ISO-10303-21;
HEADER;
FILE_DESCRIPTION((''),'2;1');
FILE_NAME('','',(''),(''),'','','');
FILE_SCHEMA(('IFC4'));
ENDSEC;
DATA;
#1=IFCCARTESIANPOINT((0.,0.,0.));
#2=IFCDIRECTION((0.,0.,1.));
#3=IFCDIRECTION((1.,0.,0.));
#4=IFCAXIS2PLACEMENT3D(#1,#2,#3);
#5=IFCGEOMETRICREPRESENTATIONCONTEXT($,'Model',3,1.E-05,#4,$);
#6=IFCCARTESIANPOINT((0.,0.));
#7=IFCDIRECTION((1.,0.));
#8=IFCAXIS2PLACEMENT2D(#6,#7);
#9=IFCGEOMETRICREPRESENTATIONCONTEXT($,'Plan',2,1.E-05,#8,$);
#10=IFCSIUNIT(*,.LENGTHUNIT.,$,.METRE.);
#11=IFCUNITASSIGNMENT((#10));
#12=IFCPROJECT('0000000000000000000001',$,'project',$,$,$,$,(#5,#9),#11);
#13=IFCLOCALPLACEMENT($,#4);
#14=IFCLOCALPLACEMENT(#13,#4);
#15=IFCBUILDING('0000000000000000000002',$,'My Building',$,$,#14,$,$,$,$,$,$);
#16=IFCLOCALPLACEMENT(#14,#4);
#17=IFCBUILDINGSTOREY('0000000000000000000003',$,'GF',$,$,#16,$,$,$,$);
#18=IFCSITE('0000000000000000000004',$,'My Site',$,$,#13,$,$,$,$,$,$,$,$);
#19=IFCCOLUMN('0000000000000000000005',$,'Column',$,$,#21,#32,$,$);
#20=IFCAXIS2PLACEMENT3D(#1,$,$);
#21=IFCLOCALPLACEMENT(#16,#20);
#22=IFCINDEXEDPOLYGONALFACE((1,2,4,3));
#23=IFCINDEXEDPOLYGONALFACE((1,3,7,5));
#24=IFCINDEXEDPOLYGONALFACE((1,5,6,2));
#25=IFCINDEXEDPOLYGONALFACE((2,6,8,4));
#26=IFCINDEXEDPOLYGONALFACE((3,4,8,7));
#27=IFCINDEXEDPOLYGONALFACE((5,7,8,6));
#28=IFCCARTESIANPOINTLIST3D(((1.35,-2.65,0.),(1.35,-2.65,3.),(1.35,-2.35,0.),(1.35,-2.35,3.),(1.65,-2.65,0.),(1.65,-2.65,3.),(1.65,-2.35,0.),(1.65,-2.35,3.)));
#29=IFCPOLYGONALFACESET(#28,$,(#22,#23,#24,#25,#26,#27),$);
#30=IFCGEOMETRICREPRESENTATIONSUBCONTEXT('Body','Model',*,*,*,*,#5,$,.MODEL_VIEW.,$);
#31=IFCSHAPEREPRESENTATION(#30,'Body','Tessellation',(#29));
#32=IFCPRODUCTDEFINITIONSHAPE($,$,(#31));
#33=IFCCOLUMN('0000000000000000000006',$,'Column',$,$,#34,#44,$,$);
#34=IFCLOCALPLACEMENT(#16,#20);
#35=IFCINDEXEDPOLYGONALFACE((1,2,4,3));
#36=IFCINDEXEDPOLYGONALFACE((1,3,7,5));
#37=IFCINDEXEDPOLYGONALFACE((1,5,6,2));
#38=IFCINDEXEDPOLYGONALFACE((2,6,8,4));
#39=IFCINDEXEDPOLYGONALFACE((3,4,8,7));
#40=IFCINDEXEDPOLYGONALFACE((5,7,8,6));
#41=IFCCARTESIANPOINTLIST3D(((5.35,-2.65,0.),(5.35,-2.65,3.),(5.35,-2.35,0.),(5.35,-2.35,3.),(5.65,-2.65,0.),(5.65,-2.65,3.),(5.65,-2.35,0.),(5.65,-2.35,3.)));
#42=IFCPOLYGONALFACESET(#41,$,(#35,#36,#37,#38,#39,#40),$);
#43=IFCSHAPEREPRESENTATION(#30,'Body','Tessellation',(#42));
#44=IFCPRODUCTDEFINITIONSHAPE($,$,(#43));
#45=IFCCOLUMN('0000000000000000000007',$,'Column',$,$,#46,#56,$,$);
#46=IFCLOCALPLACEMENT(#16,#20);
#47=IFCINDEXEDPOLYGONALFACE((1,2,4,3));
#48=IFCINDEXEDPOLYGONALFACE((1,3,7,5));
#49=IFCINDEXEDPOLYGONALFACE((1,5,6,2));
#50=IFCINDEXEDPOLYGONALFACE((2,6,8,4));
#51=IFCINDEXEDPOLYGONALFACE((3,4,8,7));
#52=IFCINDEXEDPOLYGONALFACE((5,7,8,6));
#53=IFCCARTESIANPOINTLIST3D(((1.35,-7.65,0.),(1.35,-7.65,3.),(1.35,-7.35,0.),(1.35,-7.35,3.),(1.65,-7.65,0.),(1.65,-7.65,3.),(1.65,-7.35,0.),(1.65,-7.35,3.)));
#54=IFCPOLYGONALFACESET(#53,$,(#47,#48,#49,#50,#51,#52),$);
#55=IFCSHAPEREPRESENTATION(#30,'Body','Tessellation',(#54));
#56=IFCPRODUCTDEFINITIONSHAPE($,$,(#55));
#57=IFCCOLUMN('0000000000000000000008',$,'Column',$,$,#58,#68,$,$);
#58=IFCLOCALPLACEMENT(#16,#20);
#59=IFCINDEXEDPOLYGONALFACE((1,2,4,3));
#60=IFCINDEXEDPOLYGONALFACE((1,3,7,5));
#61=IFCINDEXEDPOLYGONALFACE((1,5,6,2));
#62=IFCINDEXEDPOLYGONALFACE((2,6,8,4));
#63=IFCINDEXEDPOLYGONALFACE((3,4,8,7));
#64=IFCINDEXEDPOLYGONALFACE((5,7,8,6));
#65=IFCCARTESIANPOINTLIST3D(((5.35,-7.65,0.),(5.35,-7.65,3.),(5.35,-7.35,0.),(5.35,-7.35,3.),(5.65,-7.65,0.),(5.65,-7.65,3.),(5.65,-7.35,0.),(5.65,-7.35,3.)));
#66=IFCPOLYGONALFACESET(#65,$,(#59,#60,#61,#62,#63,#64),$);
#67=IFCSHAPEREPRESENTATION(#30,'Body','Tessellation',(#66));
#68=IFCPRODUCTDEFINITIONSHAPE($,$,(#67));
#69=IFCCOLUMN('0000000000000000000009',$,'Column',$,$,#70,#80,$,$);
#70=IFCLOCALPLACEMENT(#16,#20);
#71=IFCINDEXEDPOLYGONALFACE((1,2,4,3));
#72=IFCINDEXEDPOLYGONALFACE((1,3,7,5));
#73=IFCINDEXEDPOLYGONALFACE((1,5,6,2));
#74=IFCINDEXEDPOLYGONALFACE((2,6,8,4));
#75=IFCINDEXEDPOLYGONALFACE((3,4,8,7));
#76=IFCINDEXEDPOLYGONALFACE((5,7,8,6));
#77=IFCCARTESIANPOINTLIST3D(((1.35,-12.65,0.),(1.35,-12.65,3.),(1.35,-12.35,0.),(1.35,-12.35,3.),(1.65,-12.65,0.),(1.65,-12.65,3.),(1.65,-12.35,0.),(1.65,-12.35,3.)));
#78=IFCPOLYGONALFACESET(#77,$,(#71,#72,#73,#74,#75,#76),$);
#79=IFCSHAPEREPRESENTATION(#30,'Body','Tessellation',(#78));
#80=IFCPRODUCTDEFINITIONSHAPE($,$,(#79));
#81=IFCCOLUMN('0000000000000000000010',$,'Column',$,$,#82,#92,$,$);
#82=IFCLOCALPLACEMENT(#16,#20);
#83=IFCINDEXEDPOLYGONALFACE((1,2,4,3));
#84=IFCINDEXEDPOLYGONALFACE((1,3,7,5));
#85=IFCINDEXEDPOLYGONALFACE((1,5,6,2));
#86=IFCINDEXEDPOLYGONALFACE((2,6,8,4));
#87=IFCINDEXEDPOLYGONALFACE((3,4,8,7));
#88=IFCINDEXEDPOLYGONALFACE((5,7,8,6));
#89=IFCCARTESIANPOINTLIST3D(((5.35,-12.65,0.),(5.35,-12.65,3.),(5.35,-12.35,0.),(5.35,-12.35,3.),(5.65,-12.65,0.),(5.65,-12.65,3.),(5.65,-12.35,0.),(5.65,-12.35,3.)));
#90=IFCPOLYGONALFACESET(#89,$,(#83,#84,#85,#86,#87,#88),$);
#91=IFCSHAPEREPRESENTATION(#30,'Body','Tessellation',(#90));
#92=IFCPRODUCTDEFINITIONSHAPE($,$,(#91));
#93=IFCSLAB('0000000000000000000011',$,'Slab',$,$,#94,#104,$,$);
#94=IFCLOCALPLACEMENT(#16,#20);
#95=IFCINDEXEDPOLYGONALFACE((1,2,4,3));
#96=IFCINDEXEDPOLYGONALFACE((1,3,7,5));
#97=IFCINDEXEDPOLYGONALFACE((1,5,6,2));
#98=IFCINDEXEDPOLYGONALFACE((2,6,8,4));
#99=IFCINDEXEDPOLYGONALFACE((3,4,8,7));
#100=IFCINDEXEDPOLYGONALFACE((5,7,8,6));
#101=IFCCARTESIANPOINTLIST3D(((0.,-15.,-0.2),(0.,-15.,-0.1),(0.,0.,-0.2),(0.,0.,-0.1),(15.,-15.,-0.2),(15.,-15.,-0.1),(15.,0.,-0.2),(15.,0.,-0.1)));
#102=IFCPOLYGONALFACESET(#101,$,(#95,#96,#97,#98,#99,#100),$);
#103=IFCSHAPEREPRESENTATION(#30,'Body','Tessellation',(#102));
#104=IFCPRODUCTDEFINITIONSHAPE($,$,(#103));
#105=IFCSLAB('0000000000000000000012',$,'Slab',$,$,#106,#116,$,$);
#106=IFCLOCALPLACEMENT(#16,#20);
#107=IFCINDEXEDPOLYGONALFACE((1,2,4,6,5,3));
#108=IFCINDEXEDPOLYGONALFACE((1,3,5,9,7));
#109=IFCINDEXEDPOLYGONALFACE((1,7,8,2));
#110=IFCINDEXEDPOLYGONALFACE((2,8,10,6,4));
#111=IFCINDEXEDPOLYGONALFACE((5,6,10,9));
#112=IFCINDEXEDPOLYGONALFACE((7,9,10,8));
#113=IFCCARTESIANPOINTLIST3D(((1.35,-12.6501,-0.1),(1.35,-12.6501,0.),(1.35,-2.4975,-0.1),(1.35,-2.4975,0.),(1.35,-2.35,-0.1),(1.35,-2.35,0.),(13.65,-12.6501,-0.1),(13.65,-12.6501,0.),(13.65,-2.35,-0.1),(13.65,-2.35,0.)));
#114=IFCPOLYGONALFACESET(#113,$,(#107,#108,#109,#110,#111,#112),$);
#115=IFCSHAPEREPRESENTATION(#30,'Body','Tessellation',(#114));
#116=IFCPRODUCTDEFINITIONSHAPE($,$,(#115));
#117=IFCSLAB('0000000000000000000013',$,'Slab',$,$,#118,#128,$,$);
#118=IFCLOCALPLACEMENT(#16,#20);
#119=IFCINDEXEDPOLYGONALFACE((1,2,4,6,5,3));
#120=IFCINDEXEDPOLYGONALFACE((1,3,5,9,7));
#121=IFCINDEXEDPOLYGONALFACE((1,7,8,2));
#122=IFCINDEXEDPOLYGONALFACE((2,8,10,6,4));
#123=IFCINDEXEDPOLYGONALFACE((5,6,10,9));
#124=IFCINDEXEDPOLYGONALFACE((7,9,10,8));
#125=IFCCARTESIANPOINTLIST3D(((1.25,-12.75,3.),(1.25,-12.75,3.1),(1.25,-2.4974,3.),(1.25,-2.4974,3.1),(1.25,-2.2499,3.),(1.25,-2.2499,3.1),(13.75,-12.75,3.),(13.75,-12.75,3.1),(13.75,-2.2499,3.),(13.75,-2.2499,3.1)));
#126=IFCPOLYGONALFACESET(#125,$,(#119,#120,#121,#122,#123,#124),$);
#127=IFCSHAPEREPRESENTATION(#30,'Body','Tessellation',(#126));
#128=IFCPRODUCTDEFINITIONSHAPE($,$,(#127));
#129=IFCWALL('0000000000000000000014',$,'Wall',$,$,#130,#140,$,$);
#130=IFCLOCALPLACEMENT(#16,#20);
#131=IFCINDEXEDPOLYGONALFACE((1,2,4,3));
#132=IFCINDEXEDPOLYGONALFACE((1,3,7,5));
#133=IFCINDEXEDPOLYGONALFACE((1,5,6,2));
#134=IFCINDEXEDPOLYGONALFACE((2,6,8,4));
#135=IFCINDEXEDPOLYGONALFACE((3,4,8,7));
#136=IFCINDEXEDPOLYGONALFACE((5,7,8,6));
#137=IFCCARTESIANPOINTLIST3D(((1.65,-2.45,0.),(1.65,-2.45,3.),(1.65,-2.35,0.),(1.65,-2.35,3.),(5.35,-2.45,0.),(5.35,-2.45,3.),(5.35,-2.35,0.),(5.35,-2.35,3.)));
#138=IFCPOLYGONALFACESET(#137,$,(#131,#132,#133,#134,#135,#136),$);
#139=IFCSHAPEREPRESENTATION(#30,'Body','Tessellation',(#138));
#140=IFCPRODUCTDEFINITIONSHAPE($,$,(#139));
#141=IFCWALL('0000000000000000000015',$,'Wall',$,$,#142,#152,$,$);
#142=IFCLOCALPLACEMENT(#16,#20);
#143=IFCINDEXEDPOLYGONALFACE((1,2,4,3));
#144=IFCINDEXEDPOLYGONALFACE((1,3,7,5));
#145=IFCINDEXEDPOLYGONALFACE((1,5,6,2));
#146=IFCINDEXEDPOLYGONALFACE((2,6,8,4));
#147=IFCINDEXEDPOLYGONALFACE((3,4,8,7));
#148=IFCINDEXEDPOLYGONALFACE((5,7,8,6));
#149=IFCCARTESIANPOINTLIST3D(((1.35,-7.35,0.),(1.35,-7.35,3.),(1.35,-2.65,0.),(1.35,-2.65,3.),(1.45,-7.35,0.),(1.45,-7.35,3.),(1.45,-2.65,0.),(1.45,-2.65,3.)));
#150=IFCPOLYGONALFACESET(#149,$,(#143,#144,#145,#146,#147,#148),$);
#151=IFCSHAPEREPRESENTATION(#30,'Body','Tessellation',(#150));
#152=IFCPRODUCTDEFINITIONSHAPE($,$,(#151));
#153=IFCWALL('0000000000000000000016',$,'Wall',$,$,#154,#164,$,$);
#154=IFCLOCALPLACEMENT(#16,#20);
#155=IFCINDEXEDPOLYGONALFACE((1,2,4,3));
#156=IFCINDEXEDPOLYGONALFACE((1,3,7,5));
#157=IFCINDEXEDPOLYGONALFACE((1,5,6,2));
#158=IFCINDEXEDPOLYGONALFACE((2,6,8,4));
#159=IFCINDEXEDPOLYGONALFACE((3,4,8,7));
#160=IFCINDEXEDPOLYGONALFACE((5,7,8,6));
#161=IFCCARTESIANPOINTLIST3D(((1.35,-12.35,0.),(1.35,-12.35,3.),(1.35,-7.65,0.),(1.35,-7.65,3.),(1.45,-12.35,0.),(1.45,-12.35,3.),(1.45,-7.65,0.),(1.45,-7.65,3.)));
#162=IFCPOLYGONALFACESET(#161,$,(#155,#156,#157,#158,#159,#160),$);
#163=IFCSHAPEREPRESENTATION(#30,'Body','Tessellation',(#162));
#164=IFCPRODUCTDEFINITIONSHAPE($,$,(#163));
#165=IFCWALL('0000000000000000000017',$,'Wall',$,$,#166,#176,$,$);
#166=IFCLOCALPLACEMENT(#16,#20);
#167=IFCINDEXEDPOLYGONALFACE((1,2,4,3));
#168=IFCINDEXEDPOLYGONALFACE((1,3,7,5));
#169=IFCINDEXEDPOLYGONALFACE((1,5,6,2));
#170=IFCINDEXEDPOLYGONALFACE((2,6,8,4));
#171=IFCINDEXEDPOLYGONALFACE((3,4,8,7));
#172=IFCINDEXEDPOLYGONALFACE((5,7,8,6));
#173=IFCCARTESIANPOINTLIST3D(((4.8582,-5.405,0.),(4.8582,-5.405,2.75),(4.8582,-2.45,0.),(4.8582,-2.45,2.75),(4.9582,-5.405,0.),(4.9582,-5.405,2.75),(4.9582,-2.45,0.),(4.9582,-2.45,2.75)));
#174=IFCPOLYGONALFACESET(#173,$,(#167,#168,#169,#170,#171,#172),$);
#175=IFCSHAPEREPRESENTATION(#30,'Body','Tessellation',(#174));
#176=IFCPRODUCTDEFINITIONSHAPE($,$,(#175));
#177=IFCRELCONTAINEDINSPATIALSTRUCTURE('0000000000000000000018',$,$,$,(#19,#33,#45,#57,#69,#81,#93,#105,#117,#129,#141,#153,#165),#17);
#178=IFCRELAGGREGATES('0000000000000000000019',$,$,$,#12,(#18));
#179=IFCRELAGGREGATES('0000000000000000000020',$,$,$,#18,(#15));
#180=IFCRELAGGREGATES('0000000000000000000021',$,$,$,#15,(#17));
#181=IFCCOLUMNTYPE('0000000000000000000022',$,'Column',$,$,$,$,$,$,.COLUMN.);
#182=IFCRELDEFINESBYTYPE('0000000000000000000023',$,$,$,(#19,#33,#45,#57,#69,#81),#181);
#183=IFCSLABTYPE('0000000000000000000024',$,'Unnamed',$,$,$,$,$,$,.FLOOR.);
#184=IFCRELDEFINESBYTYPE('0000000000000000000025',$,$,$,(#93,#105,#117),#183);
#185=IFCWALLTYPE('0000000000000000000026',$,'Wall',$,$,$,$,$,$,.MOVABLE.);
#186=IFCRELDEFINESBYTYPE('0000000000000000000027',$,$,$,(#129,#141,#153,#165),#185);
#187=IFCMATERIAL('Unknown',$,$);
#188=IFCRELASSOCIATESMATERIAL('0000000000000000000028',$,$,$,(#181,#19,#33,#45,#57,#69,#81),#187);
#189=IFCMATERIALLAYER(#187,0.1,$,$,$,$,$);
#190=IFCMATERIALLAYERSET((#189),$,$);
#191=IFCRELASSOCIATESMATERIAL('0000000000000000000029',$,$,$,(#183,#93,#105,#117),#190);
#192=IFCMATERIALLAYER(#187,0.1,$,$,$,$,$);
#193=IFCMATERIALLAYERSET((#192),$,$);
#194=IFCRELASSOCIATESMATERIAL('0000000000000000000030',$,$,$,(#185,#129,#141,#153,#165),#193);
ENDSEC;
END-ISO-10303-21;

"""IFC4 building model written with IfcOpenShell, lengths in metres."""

from ifc_helpers import new_model, si_unit, frame, origin_with_axes, origin_2d_with_axis, place, context, subcontext, project, spatial, line, indexed_curve, rectangle, outline, extrude, material, layer, layer_set, layer_usage, material_profile, profile_set, profile_usage, type_object, element, save


model = new_model("IFC4")

# Units and contexts
model_context = context("Model", 3, precision=1e-05, world=origin_with_axes())
plan_context = context("Plan", 2, precision=1e-05, world=origin_2d_with_axis())
body_context_1 = subcontext(model_context, "Body", "Model", "MODEL_VIEW")
ifc_project = project(units=[si_unit("LENGTHUNIT", "METRE")], contexts=[model_context, plan_context])

# Site, building, storey
site_placement = place(None, origin_with_axes())
site = spatial("IfcSite", under=ifc_project, at=site_placement, Name="My Site")
building_placement = place(site_placement, origin_with_axes())
building = spatial("IfcBuilding", under=site, at=building_placement, Name="My Building")
storey_placement = place(building_placement, origin_with_axes())
storey = spatial("IfcBuildingStorey", under=building, at=storey_placement, Name="GF")

# Columns
ifc_material_1 = material(Name="Unknown")
ifc_material_profile_1 = material_profile(ifc_material_1, rectangle(XDim=0.3, YDim=0.3))
ifc_profile_set_1 = profile_set([ifc_material_profile_1])
ifc_profile_usage_1 = profile_usage(ifc_profile_set_1, cardinal=5)
column_type = type_object("IfcColumnType", Name="Column", PredefinedType="COLUMN", material=ifc_profile_set_1)
column_1_placement = place(storey_placement, frame((1.5, -2.5, 0.0), z_axis=(0.0, 0.0, 1.0), x_axis=(1.0, 0.0, 0.0)))
element("IfcColumn", 1, at=column_1_placement, inside=storey, type_object=column_type, material=ifc_profile_usage_1, Name="Column", context=body_context_1, shape_type="SweptSolid", body=[
    extrude(rectangle(XDim=0.3, YDim=0.3), origin_with_axes(), (0.0, 0.0, 1.0), 3.0),
])
ifc_profile_usage_2 = profile_usage(ifc_profile_set_1, cardinal=5)
column_2_placement = place(storey_placement, frame((5.5, -2.5, 0.0), z_axis=(0.0, 0.0, 1.0), x_axis=(1.0, 0.0, 0.0)))
element("IfcColumn", 2, at=column_2_placement, inside=storey, type_object=column_type, material=ifc_profile_usage_2, Name="Column", context=body_context_1, shape_type="SweptSolid", body=[
    extrude(rectangle(XDim=0.3, YDim=0.3), origin_with_axes(), (0.0, 0.0, 1.0), 3.0),
])
ifc_profile_usage_3 = profile_usage(ifc_profile_set_1, cardinal=5)
column_3_placement = place(storey_placement, frame((1.5, -7.5, 0.0), z_axis=(0.0, 0.0, 1.0), x_axis=(1.0, 0.0, 0.0)))
element("IfcColumn", 3, at=column_3_placement, inside=storey, type_object=column_type, material=ifc_profile_usage_3, Name="Column", context=body_context_1, shape_type="SweptSolid", body=[
    extrude(rectangle(XDim=0.3, YDim=0.3), origin_with_axes(), (0.0, 0.0, 1.0), 3.0),
])
ifc_profile_usage_4 = profile_usage(ifc_profile_set_1, cardinal=5)
column_4_placement = place(storey_placement, frame((5.5, -7.5, 0.0), z_axis=(0.0, 0.0, 1.0), x_axis=(1.0, 0.0, 0.0)))
element("IfcColumn", 4, at=column_4_placement, inside=storey, type_object=column_type, material=ifc_profile_usage_4, Name="Column", context=body_context_1, shape_type="SweptSolid", body=[
    extrude(rectangle(XDim=0.3, YDim=0.3), origin_with_axes(), (0.0, 0.0, 1.0), 3.0),
])
ifc_profile_usage_5 = profile_usage(ifc_profile_set_1, cardinal=5)
column_5_placement = place(storey_placement, frame((1.5, -12.5, 0.0), z_axis=(0.0, 0.0, 1.0), x_axis=(1.0, 0.0, 0.0)))
element("IfcColumn", 5, at=column_5_placement, inside=storey, type_object=column_type, material=ifc_profile_usage_5, Name="Column", context=body_context_1, shape_type="SweptSolid", body=[
    extrude(rectangle(XDim=0.3, YDim=0.3), origin_with_axes(), (0.0, 0.0, 1.0), 3.0),
])
ifc_profile_usage_6 = profile_usage(ifc_profile_set_1, cardinal=5)
column_6_placement = place(storey_placement, frame((5.5, -12.5, 0.0), z_axis=(0.0, 0.0, 1.0), x_axis=(1.0, 0.0, 0.0)))
element("IfcColumn", 6, at=column_6_placement, inside=storey, type_object=column_type, material=ifc_profile_usage_6, Name="Column", context=body_context_1, shape_type="SweptSolid", body=[
    extrude(rectangle(XDim=0.3, YDim=0.3), origin_with_axes(), (0.0, 0.0, 1.0), 3.0),
])

# Slabs
ifc_layer_1 = layer(ifc_material_1, 0.1)
ifc_layer_set_1 = layer_set([ifc_layer_1])
ifc_layer_usage_1 = layer_usage(ifc_layer_set_1, "AXIS3", "POSITIVE", -0.1)
slab_type = type_object("IfcSlabType", Name="Unnamed", PredefinedType="FLOOR", material=ifc_layer_set_1)
slab_1_placement = place(storey_placement, frame((0.0, 0.0, -0.1), z_axis=(0.0, 0.0, 1.0), x_axis=(1.0, 0.0, 0.0)))
element("IfcSlab", 7, at=slab_1_placement, inside=storey, type_object=slab_type, material=ifc_layer_usage_1, Name="Slab", context=body_context_1, shape_type="SweptSolid", body=[
    extrude(outline(indexed_curve([(0.0, 0.0), (0.0, -15.0), (15.0, -15.0), (15.0, 0.0), (0.0, 0.0)])), frame((0.0, 0.0, -0.1), z_axis=(0.0, 0.0, 1.0), x_axis=(1.0, 0.0, 0.0)), (0.0, 0.0, 1.0), 0.1),
])
ifc_layer_usage_2 = layer_usage(ifc_layer_set_1, "AXIS3", "POSITIVE", -0.1)
slab_2_placement = place(storey_placement, frame((1.35, -2.4975, 0.0), z_axis=(0.0, 0.0, 1.0), x_axis=(1.0, 0.0, 0.0)))
element("IfcSlab", 8, at=slab_2_placement, inside=storey, type_object=slab_type, material=ifc_layer_usage_2, Name="Slab", context=body_context_1, shape_type="SweptSolid", body=[
    extrude(outline(indexed_curve([(0.0, 0.0), (0.0, -10.1526), (12.3, -10.1526), (12.3, 0.1475), (0.0, 0.1475), (0.0, 0.0)])), frame((0.0, 0.0, -0.1), z_axis=(0.0, 0.0, 1.0), x_axis=(1.0, 0.0, 0.0)), (0.0, 0.0, 1.0), 0.1),
])
ifc_layer_usage_3 = layer_usage(ifc_layer_set_1, "AXIS3", "POSITIVE", -0.1)
slab_3_placement = place(storey_placement, frame((1.35, -2.4974, 3.1), z_axis=(0.0, 0.0, 1.0), x_axis=(1.0, 0.0, 0.0)))
element("IfcSlab", 9, at=slab_3_placement, inside=storey, type_object=slab_type, material=ifc_layer_usage_3, Name="Slab", context=body_context_1, shape_type="SweptSolid", body=[
    extrude(outline(indexed_curve([(-0.1, 0.2475), (12.4, 0.2475), (12.4, -10.2526), (-0.1, -10.2526), (-0.1, 0.0), (-0.1, 0.2475)])), frame((0.0, 0.0, -0.1), z_axis=(0.0, 0.0, 1.0), x_axis=(1.0, 0.0, 0.0)), (0.0, 0.0, 1.0), 0.1),
])

# Walls
ifc_layer_2 = layer(ifc_material_1, 0.1)
ifc_layer_set_2 = layer_set([ifc_layer_2])
ifc_layer_usage_4 = layer_usage(ifc_layer_set_2, "AXIS2", "POSITIVE", 0.0)
wall_type_1 = type_object("IfcWallType", Name="Wall", PredefinedType="MOVABLE", material=ifc_layer_set_2)
wall_1_placement = place(storey_placement, frame((1.65, -2.45, 0.0), z_axis=(0.0, 0.0, 1.0), x_axis=(1.0, 0.0, 0.0)))
element("IfcWall", 10, at=wall_1_placement, inside=storey, type_object=wall_type_1, material=ifc_layer_usage_4, Name="Wall", context=body_context_1, shape_type="SweptSolid", body=[
    extrude(outline(indexed_curve([(0.0, 0.0), (0.0, 0.1), (3.7, 0.1), (3.7, 0.0)], segments=[line(1, 2, 3, 4, 1)])), origin_with_axes(), (0.0, 0.0, 1.0), 3.0),
])
ifc_layer_usage_5 = layer_usage(ifc_layer_set_2, "AXIS2", "POSITIVE", 0.0)
wall_2_placement = place(storey_placement, frame((1.35, -2.65, 0.0), z_axis=(0.0, 0.0, 1.0), x_axis=(0.0, -1.0, 0.0)))
element("IfcWall", 11, at=wall_2_placement, inside=storey, type_object=wall_type_1, material=ifc_layer_usage_5, Name="Wall", context=body_context_1, shape_type="SweptSolid", body=[
    extrude(outline(indexed_curve([(0.0, 0.0), (0.0, 0.1), (4.7, 0.1), (4.7, 0.0)], segments=[line(1, 2, 3, 4, 1)])), origin_with_axes(), (0.0, 0.0, 1.0), 3.0),
])
ifc_layer_usage_6 = layer_usage(ifc_layer_set_2, "AXIS2", "POSITIVE", 0.0)
wall_3_placement = place(storey_placement, frame((1.35, -7.65, 0.0), z_axis=(0.0, 0.0, 1.0), x_axis=(0.0, -1.0, 0.0)))
element("IfcWall", 12, at=wall_3_placement, inside=storey, type_object=wall_type_1, material=ifc_layer_usage_6, Name="Wall", context=body_context_1, shape_type="SweptSolid", body=[
    extrude(outline(indexed_curve([(0.0, 0.0), (0.0, 0.1), (4.7, 0.1), (4.7, 0.0)], segments=[line(1, 2, 3, 4, 1)])), origin_with_axes(), (0.0, 0.0, 1.0), 3.0),
])
ifc_layer_usage_7 = layer_usage(ifc_layer_set_2, "AXIS2", "POSITIVE", 0.0)
wall_4_placement = place(storey_placement, frame((4.9582, -5.405, 0.0), z_axis=(0.0, 0.0, 1.0), x_axis=(0.0, 1.0, 0.0)))
element("IfcWall", 13, at=wall_4_placement, inside=storey, type_object=wall_type_1, material=ifc_layer_usage_7, Name="Wall", context=body_context_1, shape_type="SweptSolid", body=[
    extrude(outline(indexed_curve([(0.0, 0.0), (0.0, 0.1), (2.955, 0.1), (2.955, 0.0)], segments=[line(1, 2, 3, 4, 1)])), origin_with_axes(), (0.0, 0.0, 1.0), 2.75),
])

save(model, "model.ifc")
